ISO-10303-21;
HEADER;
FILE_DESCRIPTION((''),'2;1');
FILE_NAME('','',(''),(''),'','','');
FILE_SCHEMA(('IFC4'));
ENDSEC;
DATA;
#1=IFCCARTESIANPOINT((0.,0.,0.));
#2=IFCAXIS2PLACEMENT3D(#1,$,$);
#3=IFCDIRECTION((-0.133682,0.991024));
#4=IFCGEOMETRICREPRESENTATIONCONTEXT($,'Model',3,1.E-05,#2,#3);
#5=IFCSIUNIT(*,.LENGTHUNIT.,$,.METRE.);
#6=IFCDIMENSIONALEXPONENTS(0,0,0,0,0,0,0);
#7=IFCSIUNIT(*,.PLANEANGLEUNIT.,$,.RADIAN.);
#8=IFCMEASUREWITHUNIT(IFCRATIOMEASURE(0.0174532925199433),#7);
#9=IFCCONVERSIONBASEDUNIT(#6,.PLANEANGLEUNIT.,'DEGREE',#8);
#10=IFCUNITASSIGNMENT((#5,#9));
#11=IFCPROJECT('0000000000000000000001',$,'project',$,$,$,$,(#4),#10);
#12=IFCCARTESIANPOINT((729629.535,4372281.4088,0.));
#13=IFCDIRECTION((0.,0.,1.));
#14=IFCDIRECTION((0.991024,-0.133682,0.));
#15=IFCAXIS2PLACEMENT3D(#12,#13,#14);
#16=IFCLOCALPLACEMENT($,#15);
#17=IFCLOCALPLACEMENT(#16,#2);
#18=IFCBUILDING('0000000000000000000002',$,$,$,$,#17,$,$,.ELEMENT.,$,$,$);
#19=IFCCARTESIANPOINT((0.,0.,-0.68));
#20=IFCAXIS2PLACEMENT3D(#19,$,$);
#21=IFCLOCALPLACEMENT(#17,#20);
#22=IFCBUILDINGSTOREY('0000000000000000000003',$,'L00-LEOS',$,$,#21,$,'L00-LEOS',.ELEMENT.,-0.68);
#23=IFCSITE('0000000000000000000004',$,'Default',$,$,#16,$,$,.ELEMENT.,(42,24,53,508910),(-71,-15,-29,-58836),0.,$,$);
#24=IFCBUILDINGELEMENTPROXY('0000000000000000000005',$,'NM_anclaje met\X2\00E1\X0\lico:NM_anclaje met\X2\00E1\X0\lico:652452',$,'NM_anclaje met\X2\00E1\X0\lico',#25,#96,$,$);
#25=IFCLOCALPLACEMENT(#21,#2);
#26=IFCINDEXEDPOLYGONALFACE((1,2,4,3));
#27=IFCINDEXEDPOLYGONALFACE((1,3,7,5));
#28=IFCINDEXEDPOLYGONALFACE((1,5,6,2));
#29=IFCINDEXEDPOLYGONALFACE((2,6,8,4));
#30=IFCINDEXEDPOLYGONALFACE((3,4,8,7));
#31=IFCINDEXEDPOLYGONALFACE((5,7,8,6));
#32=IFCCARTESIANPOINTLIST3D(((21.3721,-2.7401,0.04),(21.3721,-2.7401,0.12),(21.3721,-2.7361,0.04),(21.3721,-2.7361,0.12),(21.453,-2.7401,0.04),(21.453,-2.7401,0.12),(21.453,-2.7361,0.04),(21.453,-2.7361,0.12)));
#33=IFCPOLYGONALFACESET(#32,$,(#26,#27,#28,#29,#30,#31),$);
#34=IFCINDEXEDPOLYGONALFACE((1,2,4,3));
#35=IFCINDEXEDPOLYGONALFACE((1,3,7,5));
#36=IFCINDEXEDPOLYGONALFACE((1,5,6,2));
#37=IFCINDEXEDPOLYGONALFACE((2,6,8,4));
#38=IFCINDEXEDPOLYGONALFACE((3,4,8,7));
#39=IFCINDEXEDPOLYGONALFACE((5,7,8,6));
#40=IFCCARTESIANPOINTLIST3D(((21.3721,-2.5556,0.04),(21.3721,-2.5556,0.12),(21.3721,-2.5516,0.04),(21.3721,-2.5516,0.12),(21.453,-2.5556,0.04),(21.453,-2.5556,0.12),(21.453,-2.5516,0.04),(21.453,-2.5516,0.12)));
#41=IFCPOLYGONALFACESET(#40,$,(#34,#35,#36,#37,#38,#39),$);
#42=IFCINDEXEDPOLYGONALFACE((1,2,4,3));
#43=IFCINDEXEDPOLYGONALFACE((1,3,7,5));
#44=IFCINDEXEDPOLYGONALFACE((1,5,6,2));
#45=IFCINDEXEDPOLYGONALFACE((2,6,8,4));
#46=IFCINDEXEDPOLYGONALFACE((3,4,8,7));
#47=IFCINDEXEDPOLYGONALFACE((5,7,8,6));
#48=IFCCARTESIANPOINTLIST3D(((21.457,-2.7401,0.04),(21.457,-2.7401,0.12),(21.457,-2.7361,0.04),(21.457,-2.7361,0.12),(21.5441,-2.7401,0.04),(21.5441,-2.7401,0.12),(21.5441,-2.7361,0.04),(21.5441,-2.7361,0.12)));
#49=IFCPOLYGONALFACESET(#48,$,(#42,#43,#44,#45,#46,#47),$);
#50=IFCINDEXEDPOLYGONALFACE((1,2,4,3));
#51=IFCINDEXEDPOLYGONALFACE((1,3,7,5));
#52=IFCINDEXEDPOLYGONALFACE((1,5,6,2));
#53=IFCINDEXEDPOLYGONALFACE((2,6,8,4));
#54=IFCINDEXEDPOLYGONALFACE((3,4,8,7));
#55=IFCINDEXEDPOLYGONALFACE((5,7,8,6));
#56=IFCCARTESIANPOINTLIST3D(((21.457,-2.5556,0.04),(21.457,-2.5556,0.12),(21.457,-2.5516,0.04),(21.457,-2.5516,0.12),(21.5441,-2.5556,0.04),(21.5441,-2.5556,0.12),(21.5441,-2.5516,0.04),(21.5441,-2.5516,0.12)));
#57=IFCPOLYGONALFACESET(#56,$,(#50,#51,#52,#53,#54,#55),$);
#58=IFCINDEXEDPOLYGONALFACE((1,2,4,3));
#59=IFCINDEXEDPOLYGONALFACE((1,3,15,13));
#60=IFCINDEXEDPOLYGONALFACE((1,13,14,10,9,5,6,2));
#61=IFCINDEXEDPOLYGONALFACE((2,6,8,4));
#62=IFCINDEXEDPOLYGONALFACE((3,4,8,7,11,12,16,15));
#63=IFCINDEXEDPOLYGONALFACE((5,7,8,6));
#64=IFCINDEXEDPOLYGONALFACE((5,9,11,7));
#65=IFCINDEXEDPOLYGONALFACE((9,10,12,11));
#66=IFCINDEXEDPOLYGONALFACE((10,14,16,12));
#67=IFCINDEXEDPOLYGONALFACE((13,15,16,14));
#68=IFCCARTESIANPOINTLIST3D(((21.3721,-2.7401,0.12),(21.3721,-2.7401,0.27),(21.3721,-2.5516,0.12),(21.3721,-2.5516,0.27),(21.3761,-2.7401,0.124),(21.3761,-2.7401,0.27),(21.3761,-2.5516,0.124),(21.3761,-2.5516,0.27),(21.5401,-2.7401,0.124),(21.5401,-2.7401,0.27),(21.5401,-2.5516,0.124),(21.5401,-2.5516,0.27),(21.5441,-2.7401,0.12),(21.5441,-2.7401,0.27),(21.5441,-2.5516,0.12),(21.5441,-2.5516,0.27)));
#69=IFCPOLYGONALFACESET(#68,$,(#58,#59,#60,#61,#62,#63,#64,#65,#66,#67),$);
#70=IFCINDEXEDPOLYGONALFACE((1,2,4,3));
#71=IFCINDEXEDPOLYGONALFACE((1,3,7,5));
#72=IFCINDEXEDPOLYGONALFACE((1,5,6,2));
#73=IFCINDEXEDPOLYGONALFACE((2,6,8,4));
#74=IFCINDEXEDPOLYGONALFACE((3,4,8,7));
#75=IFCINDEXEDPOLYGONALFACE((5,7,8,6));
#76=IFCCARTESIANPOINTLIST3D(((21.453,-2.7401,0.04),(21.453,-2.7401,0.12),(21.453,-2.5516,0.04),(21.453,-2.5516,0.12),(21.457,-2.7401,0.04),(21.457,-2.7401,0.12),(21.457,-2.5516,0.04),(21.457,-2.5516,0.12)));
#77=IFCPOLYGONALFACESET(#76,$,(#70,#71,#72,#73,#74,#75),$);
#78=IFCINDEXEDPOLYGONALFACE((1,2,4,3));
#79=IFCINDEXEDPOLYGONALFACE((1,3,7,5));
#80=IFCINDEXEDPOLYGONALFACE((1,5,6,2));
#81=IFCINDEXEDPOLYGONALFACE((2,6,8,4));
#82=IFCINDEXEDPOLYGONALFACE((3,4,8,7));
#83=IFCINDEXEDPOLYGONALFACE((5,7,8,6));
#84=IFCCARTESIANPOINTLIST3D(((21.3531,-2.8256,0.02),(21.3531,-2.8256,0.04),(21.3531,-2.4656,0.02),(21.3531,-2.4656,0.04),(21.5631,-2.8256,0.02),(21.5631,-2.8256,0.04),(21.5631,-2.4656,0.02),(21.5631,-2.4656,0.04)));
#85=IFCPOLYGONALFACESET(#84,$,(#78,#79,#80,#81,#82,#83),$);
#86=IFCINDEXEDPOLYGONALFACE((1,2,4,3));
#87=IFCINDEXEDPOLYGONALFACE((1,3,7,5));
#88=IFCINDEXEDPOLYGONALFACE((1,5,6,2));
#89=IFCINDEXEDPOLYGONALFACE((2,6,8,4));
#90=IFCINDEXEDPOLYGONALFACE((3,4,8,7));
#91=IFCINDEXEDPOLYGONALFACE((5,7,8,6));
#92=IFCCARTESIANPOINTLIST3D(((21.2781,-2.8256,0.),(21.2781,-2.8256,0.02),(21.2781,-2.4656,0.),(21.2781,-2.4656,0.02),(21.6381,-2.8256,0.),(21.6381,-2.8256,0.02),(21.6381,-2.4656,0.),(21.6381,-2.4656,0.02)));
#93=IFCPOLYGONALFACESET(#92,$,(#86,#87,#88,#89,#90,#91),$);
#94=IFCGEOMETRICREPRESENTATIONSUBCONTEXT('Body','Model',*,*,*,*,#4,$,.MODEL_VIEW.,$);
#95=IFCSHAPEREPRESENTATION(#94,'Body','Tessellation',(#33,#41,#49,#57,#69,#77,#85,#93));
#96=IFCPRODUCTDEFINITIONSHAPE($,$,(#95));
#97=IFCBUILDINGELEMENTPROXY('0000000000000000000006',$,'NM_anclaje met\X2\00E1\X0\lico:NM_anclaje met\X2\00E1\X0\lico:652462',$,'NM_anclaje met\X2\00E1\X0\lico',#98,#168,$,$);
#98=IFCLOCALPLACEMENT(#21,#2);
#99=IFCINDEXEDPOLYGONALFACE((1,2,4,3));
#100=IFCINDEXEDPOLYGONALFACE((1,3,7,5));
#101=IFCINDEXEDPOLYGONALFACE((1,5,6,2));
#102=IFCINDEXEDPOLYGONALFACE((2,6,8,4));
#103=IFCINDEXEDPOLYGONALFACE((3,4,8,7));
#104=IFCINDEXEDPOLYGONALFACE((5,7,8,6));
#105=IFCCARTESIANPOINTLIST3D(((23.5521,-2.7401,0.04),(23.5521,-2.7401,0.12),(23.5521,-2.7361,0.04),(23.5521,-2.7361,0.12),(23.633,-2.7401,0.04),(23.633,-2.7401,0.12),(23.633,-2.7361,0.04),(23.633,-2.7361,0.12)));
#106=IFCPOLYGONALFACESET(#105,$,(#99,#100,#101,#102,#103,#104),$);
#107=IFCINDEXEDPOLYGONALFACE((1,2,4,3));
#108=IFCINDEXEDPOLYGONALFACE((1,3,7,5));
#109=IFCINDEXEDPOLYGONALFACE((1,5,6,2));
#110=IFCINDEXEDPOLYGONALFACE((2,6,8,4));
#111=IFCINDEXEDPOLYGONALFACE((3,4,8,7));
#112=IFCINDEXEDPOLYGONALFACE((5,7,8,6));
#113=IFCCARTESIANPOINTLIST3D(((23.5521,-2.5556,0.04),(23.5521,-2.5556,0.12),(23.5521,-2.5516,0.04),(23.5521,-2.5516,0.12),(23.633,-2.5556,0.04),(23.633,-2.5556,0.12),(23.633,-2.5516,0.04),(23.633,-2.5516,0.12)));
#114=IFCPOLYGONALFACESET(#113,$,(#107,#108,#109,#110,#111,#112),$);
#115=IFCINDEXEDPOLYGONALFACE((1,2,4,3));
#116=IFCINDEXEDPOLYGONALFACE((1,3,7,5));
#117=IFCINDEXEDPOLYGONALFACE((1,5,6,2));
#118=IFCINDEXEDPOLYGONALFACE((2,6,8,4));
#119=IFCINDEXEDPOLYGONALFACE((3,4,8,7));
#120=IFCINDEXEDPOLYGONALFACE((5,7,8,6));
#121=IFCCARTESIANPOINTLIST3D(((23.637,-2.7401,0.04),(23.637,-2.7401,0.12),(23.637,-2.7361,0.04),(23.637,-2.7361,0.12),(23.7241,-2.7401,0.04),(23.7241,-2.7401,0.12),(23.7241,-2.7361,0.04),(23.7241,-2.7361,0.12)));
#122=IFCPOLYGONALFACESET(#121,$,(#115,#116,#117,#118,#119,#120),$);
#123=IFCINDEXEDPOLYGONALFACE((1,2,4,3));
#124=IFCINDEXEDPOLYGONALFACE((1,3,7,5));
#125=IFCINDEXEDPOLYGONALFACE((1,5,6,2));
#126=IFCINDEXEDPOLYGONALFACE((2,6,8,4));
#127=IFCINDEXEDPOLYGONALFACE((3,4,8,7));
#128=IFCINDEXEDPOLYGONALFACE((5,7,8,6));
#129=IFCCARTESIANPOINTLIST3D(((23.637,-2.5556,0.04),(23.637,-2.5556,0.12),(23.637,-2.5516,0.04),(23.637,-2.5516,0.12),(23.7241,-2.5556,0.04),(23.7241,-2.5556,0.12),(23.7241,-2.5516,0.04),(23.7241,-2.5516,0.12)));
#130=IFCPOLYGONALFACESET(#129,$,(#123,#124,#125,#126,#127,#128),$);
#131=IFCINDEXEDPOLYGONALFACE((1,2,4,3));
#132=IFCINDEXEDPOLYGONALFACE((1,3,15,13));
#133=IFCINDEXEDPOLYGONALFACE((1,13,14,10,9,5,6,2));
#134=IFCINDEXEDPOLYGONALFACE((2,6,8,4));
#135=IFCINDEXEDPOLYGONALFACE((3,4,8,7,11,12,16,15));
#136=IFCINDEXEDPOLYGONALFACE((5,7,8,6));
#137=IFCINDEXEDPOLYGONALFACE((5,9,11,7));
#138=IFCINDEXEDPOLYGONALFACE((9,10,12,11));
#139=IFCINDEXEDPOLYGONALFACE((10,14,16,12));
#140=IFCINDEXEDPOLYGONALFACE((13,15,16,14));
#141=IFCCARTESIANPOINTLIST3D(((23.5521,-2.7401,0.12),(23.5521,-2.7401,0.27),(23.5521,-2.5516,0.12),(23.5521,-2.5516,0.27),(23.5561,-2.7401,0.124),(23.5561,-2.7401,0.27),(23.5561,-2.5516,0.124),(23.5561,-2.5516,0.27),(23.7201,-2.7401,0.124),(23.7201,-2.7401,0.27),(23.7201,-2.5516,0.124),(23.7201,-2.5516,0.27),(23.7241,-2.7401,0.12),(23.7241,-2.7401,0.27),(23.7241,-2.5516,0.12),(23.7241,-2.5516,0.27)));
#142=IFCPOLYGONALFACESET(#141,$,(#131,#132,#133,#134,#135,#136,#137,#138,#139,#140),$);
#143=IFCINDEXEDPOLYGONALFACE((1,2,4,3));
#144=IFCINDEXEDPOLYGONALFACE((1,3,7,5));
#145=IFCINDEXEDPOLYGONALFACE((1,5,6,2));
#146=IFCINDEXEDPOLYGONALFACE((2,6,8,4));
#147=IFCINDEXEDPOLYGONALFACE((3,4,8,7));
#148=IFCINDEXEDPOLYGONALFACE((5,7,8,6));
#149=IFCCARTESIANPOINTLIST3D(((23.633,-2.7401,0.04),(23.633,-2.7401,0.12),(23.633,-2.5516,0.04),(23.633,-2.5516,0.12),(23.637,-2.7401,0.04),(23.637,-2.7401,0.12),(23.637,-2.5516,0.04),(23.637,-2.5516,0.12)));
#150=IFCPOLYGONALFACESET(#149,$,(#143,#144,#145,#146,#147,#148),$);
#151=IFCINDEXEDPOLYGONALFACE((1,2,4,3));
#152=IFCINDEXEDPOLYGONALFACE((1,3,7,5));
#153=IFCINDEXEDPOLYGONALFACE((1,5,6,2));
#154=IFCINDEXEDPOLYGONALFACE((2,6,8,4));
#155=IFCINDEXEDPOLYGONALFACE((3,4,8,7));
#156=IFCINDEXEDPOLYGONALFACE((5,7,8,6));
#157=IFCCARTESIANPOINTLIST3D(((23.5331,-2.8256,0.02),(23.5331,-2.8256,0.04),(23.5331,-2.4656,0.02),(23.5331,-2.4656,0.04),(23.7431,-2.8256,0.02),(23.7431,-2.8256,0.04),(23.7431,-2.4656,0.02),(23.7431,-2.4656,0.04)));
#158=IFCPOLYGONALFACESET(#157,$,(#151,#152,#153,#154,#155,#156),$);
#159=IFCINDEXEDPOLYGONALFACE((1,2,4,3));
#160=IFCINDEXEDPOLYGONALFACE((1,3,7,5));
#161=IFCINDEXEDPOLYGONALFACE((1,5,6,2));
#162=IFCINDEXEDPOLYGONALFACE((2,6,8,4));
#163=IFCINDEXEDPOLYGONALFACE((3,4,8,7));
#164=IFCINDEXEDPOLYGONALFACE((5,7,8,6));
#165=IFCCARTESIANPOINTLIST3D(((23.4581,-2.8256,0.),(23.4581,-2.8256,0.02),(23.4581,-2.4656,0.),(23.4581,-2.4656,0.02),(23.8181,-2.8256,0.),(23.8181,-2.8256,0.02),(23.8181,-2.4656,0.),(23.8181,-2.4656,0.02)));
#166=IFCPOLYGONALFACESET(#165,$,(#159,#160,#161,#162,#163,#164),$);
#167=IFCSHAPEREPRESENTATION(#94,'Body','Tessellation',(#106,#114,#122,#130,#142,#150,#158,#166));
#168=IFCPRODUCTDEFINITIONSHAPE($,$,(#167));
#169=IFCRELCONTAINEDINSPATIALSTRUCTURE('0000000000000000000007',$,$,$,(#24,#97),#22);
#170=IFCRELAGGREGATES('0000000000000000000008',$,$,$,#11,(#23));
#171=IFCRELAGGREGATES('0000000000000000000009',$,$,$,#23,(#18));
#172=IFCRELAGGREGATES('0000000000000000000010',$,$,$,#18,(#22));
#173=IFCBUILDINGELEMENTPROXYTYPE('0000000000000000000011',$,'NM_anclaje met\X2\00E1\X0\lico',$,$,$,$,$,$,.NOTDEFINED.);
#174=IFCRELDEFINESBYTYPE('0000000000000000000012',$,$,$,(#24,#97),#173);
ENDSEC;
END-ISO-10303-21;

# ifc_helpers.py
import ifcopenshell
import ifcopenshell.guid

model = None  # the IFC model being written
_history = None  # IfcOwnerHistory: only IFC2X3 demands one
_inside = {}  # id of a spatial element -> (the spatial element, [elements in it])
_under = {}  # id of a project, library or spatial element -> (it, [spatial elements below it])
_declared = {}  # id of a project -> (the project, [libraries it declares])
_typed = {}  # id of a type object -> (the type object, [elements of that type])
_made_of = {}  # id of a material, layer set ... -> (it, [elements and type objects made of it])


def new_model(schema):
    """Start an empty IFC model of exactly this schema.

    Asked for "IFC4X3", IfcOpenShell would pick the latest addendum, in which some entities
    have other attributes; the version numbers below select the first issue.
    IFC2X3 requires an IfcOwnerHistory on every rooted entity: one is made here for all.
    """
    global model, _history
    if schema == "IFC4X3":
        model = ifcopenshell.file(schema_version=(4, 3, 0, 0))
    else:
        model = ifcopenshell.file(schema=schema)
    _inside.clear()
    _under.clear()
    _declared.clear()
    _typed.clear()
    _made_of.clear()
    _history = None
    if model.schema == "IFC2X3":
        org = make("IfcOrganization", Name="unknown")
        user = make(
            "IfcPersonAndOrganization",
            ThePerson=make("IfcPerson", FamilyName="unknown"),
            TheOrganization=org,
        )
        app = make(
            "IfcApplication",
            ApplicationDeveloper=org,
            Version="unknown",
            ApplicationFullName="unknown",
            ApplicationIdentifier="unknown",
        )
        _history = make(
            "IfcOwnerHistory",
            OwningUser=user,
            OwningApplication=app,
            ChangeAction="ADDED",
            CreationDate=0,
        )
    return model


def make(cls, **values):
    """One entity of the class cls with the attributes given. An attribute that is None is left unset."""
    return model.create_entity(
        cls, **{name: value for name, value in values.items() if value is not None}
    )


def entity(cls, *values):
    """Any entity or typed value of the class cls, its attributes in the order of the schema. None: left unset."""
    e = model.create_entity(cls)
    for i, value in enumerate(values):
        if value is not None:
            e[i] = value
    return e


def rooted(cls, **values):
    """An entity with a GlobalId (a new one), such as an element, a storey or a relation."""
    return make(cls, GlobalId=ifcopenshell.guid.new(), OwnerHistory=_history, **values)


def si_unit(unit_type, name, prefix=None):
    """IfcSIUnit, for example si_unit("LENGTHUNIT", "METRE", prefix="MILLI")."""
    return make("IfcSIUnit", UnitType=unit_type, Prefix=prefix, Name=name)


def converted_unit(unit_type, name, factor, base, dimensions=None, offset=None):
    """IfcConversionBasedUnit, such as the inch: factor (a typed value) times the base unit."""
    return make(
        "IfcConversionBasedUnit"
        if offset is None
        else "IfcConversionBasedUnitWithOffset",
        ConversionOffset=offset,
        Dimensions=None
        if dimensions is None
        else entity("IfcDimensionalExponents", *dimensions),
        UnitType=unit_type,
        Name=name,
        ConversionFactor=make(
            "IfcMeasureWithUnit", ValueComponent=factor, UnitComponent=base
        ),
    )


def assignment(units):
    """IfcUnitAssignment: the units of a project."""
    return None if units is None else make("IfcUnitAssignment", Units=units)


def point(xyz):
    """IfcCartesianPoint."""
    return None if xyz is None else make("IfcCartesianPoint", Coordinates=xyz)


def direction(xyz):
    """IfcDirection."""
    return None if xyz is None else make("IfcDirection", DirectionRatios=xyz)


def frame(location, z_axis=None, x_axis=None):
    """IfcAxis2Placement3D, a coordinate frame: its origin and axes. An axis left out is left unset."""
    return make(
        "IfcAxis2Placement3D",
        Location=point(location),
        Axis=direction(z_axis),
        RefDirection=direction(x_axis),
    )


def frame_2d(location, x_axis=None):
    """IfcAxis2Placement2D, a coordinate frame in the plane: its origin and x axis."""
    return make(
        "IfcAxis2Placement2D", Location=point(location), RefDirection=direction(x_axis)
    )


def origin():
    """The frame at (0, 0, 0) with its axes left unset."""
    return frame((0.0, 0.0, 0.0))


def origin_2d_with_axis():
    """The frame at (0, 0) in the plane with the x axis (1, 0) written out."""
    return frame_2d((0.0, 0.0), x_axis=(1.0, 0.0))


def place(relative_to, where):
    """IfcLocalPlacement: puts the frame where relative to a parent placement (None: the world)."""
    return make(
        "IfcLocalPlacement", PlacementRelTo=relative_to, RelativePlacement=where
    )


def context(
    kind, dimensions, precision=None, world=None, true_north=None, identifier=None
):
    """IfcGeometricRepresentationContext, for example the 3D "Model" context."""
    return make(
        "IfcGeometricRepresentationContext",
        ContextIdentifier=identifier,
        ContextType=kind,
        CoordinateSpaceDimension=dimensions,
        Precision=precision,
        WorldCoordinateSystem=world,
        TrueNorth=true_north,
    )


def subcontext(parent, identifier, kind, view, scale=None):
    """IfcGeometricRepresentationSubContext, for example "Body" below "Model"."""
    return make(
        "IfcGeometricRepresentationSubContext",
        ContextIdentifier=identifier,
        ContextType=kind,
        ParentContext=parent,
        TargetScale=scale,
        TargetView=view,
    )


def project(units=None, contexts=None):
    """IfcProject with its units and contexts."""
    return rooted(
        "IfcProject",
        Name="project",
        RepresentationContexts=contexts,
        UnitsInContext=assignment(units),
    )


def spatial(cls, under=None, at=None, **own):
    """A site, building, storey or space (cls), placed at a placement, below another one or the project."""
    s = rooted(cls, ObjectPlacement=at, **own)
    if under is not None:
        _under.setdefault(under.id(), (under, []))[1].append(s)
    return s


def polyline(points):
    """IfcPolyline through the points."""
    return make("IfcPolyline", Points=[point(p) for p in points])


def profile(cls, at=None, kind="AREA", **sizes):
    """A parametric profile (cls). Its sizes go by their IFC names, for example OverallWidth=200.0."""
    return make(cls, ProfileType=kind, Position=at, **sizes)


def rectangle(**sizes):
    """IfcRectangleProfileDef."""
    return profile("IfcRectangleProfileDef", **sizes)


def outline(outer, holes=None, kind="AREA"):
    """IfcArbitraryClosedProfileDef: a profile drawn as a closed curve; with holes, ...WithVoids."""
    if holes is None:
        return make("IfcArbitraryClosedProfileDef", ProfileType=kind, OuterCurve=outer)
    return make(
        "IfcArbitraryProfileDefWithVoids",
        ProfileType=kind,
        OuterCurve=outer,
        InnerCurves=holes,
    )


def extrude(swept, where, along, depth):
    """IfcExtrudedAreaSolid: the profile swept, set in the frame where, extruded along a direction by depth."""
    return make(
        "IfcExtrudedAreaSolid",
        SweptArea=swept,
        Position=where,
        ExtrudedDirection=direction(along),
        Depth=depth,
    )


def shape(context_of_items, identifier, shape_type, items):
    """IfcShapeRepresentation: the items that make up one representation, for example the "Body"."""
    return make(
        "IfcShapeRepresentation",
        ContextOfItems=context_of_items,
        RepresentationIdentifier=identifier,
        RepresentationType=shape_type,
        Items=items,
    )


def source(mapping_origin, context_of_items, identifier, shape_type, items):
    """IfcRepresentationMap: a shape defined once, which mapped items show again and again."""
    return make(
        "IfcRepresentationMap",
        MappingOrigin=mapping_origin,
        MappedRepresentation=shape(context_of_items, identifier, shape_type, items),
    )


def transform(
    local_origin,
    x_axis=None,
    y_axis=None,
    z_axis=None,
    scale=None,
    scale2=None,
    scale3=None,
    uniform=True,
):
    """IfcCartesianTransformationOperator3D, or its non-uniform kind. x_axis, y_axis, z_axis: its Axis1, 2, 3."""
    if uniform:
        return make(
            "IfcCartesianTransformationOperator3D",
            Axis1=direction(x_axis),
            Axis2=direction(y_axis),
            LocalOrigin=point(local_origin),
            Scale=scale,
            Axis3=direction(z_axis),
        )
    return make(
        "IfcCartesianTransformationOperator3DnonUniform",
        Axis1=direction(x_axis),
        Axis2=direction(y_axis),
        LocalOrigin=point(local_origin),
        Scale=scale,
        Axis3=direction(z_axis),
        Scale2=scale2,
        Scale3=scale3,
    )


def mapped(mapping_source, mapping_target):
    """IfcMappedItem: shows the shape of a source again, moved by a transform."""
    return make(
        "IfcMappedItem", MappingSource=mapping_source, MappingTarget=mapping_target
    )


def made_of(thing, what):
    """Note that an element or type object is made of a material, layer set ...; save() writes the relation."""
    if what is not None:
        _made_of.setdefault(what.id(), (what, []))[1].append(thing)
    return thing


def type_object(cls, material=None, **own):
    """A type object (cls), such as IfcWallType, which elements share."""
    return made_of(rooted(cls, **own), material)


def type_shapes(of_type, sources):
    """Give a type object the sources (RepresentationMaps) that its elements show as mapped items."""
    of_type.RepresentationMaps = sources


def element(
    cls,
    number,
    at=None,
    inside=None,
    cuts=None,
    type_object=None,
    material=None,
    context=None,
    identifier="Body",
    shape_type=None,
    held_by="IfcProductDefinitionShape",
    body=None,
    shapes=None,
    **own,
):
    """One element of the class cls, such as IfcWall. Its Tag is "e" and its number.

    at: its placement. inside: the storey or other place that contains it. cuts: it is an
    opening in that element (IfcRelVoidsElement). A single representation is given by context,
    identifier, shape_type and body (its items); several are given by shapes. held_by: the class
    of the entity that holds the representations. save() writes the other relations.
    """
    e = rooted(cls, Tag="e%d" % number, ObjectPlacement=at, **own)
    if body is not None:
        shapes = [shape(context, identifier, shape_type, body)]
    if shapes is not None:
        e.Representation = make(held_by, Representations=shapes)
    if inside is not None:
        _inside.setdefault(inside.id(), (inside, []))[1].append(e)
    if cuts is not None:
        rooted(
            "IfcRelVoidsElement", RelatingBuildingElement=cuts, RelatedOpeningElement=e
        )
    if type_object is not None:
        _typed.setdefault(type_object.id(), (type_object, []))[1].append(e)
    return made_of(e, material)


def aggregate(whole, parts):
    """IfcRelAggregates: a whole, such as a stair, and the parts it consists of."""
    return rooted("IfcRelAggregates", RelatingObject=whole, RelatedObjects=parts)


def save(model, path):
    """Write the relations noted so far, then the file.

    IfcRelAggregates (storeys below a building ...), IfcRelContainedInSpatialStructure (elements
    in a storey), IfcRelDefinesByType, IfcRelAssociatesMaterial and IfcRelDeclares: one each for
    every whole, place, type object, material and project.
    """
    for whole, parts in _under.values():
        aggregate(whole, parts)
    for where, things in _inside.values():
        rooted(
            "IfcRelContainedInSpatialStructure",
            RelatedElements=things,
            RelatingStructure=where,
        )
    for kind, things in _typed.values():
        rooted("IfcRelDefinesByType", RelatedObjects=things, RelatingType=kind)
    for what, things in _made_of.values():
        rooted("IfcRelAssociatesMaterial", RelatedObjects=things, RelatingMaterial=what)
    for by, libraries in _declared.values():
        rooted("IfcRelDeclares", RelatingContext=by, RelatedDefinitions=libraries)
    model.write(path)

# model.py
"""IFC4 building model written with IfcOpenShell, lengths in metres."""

from ifc_helpers import new_model, entity, si_unit, converted_unit, direction, frame, frame_2d, origin, origin_2d_with_axis, place, context, subcontext, project, spatial, polyline, rectangle, outline, extrude, source, transform, mapped, type_object, type_shapes, element, save


model = new_model("IFC4")

# Units and contexts
model_context = context("Model", 3, precision=1e-05, world=origin(), true_north=direction((-0.133682, 0.991024)))
body_context = subcontext(model_context, "Body", "Model", "MODEL_VIEW")
ifc_project = project(units=[si_unit("LENGTHUNIT", "METRE"), converted_unit("PLANEANGLEUNIT", "DEGREE", entity("IfcRatioMeasure", 0.0174532925199433), si_unit("PLANEANGLEUNIT", "RADIAN"), dimensions=[0, 0, 0, 0, 0, 0, 0])], contexts=[model_context])

# Site, building, storey
site_placement = place(None, frame((729629.535, 4372281.4088, 0.0), z_axis=(0.0, 0.0, 1.0), x_axis=(0.991024, -0.133682, 0.0)))
site = spatial("IfcSite", under=ifc_project, at=site_placement, Name="Default", CompositionType="ELEMENT", RefLatitude=(42, 24, 53, 508910), RefLongitude=(-71, -15, -29, -58836), RefElevation=0.0)
building_placement = place(site_placement, origin())
building = spatial("IfcBuilding", under=site, at=building_placement, CompositionType="ELEMENT")
storey_placement = place(building_placement, frame((0.0, 0.0, -0.68)))
storey = spatial("IfcBuildingStorey", under=building, at=storey_placement, Name="L00-LEOS", LongName="L00-LEOS", CompositionType="ELEMENT", Elevation=-0.68)

# Building element proxies
building_element_proxy_type_1 = type_object("IfcBuildingElementProxyType", Name="NM_anclaje metálico")
shared_shape_1 = source(origin(), body_context, "Body", "SweptSolid", [
    extrude(rectangle(XDim=0.0809, YDim=0.004, at=frame_2d((0.0, 0.0), x_axis=(1.0, 0.0))), frame((0.0925, -0.0424, 0.04), z_axis=(0.0, 0.0, 1.0), x_axis=(0.0, 1.0, 0.0)), (0.0, 0.0, 1.0), 0.08),
    extrude(rectangle(XDim=0.0809, YDim=0.004, at=frame_2d((0.0, 0.0), x_axis=(1.0, 0.0))), frame((-0.092, -0.0424, 0.04), z_axis=(0.0, 0.0, 1.0), x_axis=(0.0, 1.0, 0.0)), (0.0, 0.0, 1.0), 0.08),
    extrude(rectangle(XDim=0.0871, YDim=0.004, at=origin_2d_with_axis()), frame((0.0925, 0.0456, 0.04), z_axis=(0.0, 0.0, 1.0), x_axis=(0.0, 1.0, 0.0)), (0.0, 0.0, 1.0), 0.08),
    extrude(rectangle(XDim=0.0871, YDim=0.004, at=frame_2d((0.0, 0.0), x_axis=(1.0, 0.0))), frame((-0.092, 0.0456, 0.04), z_axis=(0.0, 0.0, 1.0), x_axis=(0.0, 1.0, 0.0)), (0.0, 0.0, 1.0), 0.08),
    extrude(outline(polyline([(-0.076, -0.086), (0.074, -0.086), (0.074, -0.082), (-0.072, -0.082), (-0.072, 0.082), (0.074, 0.082), (0.074, 0.086), (-0.076, 0.086), (-0.076, -0.086)])), frame((-0.094, 0.0031, 0.196), z_axis=(1.0, 0.0, 0.0), x_axis=(0.0, 0.0, 1.0)), (0.0, 0.0, 1.0), 0.1885),
    extrude(rectangle(XDim=0.004, YDim=0.1885, at=frame_2d((0.0, 0.0), x_axis=(1.0, 0.0))), frame((0.0002, 0.0, 0.04), z_axis=(0.0, 0.0, 1.0), x_axis=(0.0, -1.0, 0.0)), (0.0, 0.0, 1.0), 0.08),
    extrude(rectangle(XDim=0.36, YDim=0.21, at=frame_2d((0.0, 0.0), x_axis=(1.0, 0.0))), frame((0.0, 0.0031, 0.02), z_axis=(0.0, 0.0, 1.0), x_axis=(-1.0, 0.0, 0.0)), (0.0, 0.0, 1.0), 0.02),
    extrude(rectangle(XDim=0.36, YDim=0.36, at=frame_2d((0.0, 0.0), x_axis=(1.0, 0.0))), frame((0.0, 0.0031, 0.0), z_axis=(0.0, 0.0, 1.0), x_axis=(-1.0, 0.0, 0.0)), (0.0, 0.0, 1.0), 0.02),
])
type_shapes(building_element_proxy_type_1, [shared_shape_1])
for number, where, z_axis, x_axis, name in (
    (1, (21.455, -2.6456, 0.0), (0.0, 0.0, 1.0), (0.0, -1.0, 0.0), "NM_anclaje metálico:NM_anclaje metálico:652452"),
    (2, (23.635, -2.6456, 0.0), (0.0, 0.0, 1.0), (0.0, -1.0, 0.0), "NM_anclaje metálico:NM_anclaje metálico:652462"),
):
    element("IfcBuildingElementProxy", number, at=place(storey_placement, frame(where, z_axis=z_axis, x_axis=x_axis)), inside=storey, type_object=building_element_proxy_type_1, Name=name, ObjectType="NM_anclaje metálico", context=body_context, shape_type="MappedRepresentation", body=[
        mapped(shared_shape_1, transform((0.0, 0.0, 0.0), scale=1.0)),
    ])

save(model, "model.ifc")
